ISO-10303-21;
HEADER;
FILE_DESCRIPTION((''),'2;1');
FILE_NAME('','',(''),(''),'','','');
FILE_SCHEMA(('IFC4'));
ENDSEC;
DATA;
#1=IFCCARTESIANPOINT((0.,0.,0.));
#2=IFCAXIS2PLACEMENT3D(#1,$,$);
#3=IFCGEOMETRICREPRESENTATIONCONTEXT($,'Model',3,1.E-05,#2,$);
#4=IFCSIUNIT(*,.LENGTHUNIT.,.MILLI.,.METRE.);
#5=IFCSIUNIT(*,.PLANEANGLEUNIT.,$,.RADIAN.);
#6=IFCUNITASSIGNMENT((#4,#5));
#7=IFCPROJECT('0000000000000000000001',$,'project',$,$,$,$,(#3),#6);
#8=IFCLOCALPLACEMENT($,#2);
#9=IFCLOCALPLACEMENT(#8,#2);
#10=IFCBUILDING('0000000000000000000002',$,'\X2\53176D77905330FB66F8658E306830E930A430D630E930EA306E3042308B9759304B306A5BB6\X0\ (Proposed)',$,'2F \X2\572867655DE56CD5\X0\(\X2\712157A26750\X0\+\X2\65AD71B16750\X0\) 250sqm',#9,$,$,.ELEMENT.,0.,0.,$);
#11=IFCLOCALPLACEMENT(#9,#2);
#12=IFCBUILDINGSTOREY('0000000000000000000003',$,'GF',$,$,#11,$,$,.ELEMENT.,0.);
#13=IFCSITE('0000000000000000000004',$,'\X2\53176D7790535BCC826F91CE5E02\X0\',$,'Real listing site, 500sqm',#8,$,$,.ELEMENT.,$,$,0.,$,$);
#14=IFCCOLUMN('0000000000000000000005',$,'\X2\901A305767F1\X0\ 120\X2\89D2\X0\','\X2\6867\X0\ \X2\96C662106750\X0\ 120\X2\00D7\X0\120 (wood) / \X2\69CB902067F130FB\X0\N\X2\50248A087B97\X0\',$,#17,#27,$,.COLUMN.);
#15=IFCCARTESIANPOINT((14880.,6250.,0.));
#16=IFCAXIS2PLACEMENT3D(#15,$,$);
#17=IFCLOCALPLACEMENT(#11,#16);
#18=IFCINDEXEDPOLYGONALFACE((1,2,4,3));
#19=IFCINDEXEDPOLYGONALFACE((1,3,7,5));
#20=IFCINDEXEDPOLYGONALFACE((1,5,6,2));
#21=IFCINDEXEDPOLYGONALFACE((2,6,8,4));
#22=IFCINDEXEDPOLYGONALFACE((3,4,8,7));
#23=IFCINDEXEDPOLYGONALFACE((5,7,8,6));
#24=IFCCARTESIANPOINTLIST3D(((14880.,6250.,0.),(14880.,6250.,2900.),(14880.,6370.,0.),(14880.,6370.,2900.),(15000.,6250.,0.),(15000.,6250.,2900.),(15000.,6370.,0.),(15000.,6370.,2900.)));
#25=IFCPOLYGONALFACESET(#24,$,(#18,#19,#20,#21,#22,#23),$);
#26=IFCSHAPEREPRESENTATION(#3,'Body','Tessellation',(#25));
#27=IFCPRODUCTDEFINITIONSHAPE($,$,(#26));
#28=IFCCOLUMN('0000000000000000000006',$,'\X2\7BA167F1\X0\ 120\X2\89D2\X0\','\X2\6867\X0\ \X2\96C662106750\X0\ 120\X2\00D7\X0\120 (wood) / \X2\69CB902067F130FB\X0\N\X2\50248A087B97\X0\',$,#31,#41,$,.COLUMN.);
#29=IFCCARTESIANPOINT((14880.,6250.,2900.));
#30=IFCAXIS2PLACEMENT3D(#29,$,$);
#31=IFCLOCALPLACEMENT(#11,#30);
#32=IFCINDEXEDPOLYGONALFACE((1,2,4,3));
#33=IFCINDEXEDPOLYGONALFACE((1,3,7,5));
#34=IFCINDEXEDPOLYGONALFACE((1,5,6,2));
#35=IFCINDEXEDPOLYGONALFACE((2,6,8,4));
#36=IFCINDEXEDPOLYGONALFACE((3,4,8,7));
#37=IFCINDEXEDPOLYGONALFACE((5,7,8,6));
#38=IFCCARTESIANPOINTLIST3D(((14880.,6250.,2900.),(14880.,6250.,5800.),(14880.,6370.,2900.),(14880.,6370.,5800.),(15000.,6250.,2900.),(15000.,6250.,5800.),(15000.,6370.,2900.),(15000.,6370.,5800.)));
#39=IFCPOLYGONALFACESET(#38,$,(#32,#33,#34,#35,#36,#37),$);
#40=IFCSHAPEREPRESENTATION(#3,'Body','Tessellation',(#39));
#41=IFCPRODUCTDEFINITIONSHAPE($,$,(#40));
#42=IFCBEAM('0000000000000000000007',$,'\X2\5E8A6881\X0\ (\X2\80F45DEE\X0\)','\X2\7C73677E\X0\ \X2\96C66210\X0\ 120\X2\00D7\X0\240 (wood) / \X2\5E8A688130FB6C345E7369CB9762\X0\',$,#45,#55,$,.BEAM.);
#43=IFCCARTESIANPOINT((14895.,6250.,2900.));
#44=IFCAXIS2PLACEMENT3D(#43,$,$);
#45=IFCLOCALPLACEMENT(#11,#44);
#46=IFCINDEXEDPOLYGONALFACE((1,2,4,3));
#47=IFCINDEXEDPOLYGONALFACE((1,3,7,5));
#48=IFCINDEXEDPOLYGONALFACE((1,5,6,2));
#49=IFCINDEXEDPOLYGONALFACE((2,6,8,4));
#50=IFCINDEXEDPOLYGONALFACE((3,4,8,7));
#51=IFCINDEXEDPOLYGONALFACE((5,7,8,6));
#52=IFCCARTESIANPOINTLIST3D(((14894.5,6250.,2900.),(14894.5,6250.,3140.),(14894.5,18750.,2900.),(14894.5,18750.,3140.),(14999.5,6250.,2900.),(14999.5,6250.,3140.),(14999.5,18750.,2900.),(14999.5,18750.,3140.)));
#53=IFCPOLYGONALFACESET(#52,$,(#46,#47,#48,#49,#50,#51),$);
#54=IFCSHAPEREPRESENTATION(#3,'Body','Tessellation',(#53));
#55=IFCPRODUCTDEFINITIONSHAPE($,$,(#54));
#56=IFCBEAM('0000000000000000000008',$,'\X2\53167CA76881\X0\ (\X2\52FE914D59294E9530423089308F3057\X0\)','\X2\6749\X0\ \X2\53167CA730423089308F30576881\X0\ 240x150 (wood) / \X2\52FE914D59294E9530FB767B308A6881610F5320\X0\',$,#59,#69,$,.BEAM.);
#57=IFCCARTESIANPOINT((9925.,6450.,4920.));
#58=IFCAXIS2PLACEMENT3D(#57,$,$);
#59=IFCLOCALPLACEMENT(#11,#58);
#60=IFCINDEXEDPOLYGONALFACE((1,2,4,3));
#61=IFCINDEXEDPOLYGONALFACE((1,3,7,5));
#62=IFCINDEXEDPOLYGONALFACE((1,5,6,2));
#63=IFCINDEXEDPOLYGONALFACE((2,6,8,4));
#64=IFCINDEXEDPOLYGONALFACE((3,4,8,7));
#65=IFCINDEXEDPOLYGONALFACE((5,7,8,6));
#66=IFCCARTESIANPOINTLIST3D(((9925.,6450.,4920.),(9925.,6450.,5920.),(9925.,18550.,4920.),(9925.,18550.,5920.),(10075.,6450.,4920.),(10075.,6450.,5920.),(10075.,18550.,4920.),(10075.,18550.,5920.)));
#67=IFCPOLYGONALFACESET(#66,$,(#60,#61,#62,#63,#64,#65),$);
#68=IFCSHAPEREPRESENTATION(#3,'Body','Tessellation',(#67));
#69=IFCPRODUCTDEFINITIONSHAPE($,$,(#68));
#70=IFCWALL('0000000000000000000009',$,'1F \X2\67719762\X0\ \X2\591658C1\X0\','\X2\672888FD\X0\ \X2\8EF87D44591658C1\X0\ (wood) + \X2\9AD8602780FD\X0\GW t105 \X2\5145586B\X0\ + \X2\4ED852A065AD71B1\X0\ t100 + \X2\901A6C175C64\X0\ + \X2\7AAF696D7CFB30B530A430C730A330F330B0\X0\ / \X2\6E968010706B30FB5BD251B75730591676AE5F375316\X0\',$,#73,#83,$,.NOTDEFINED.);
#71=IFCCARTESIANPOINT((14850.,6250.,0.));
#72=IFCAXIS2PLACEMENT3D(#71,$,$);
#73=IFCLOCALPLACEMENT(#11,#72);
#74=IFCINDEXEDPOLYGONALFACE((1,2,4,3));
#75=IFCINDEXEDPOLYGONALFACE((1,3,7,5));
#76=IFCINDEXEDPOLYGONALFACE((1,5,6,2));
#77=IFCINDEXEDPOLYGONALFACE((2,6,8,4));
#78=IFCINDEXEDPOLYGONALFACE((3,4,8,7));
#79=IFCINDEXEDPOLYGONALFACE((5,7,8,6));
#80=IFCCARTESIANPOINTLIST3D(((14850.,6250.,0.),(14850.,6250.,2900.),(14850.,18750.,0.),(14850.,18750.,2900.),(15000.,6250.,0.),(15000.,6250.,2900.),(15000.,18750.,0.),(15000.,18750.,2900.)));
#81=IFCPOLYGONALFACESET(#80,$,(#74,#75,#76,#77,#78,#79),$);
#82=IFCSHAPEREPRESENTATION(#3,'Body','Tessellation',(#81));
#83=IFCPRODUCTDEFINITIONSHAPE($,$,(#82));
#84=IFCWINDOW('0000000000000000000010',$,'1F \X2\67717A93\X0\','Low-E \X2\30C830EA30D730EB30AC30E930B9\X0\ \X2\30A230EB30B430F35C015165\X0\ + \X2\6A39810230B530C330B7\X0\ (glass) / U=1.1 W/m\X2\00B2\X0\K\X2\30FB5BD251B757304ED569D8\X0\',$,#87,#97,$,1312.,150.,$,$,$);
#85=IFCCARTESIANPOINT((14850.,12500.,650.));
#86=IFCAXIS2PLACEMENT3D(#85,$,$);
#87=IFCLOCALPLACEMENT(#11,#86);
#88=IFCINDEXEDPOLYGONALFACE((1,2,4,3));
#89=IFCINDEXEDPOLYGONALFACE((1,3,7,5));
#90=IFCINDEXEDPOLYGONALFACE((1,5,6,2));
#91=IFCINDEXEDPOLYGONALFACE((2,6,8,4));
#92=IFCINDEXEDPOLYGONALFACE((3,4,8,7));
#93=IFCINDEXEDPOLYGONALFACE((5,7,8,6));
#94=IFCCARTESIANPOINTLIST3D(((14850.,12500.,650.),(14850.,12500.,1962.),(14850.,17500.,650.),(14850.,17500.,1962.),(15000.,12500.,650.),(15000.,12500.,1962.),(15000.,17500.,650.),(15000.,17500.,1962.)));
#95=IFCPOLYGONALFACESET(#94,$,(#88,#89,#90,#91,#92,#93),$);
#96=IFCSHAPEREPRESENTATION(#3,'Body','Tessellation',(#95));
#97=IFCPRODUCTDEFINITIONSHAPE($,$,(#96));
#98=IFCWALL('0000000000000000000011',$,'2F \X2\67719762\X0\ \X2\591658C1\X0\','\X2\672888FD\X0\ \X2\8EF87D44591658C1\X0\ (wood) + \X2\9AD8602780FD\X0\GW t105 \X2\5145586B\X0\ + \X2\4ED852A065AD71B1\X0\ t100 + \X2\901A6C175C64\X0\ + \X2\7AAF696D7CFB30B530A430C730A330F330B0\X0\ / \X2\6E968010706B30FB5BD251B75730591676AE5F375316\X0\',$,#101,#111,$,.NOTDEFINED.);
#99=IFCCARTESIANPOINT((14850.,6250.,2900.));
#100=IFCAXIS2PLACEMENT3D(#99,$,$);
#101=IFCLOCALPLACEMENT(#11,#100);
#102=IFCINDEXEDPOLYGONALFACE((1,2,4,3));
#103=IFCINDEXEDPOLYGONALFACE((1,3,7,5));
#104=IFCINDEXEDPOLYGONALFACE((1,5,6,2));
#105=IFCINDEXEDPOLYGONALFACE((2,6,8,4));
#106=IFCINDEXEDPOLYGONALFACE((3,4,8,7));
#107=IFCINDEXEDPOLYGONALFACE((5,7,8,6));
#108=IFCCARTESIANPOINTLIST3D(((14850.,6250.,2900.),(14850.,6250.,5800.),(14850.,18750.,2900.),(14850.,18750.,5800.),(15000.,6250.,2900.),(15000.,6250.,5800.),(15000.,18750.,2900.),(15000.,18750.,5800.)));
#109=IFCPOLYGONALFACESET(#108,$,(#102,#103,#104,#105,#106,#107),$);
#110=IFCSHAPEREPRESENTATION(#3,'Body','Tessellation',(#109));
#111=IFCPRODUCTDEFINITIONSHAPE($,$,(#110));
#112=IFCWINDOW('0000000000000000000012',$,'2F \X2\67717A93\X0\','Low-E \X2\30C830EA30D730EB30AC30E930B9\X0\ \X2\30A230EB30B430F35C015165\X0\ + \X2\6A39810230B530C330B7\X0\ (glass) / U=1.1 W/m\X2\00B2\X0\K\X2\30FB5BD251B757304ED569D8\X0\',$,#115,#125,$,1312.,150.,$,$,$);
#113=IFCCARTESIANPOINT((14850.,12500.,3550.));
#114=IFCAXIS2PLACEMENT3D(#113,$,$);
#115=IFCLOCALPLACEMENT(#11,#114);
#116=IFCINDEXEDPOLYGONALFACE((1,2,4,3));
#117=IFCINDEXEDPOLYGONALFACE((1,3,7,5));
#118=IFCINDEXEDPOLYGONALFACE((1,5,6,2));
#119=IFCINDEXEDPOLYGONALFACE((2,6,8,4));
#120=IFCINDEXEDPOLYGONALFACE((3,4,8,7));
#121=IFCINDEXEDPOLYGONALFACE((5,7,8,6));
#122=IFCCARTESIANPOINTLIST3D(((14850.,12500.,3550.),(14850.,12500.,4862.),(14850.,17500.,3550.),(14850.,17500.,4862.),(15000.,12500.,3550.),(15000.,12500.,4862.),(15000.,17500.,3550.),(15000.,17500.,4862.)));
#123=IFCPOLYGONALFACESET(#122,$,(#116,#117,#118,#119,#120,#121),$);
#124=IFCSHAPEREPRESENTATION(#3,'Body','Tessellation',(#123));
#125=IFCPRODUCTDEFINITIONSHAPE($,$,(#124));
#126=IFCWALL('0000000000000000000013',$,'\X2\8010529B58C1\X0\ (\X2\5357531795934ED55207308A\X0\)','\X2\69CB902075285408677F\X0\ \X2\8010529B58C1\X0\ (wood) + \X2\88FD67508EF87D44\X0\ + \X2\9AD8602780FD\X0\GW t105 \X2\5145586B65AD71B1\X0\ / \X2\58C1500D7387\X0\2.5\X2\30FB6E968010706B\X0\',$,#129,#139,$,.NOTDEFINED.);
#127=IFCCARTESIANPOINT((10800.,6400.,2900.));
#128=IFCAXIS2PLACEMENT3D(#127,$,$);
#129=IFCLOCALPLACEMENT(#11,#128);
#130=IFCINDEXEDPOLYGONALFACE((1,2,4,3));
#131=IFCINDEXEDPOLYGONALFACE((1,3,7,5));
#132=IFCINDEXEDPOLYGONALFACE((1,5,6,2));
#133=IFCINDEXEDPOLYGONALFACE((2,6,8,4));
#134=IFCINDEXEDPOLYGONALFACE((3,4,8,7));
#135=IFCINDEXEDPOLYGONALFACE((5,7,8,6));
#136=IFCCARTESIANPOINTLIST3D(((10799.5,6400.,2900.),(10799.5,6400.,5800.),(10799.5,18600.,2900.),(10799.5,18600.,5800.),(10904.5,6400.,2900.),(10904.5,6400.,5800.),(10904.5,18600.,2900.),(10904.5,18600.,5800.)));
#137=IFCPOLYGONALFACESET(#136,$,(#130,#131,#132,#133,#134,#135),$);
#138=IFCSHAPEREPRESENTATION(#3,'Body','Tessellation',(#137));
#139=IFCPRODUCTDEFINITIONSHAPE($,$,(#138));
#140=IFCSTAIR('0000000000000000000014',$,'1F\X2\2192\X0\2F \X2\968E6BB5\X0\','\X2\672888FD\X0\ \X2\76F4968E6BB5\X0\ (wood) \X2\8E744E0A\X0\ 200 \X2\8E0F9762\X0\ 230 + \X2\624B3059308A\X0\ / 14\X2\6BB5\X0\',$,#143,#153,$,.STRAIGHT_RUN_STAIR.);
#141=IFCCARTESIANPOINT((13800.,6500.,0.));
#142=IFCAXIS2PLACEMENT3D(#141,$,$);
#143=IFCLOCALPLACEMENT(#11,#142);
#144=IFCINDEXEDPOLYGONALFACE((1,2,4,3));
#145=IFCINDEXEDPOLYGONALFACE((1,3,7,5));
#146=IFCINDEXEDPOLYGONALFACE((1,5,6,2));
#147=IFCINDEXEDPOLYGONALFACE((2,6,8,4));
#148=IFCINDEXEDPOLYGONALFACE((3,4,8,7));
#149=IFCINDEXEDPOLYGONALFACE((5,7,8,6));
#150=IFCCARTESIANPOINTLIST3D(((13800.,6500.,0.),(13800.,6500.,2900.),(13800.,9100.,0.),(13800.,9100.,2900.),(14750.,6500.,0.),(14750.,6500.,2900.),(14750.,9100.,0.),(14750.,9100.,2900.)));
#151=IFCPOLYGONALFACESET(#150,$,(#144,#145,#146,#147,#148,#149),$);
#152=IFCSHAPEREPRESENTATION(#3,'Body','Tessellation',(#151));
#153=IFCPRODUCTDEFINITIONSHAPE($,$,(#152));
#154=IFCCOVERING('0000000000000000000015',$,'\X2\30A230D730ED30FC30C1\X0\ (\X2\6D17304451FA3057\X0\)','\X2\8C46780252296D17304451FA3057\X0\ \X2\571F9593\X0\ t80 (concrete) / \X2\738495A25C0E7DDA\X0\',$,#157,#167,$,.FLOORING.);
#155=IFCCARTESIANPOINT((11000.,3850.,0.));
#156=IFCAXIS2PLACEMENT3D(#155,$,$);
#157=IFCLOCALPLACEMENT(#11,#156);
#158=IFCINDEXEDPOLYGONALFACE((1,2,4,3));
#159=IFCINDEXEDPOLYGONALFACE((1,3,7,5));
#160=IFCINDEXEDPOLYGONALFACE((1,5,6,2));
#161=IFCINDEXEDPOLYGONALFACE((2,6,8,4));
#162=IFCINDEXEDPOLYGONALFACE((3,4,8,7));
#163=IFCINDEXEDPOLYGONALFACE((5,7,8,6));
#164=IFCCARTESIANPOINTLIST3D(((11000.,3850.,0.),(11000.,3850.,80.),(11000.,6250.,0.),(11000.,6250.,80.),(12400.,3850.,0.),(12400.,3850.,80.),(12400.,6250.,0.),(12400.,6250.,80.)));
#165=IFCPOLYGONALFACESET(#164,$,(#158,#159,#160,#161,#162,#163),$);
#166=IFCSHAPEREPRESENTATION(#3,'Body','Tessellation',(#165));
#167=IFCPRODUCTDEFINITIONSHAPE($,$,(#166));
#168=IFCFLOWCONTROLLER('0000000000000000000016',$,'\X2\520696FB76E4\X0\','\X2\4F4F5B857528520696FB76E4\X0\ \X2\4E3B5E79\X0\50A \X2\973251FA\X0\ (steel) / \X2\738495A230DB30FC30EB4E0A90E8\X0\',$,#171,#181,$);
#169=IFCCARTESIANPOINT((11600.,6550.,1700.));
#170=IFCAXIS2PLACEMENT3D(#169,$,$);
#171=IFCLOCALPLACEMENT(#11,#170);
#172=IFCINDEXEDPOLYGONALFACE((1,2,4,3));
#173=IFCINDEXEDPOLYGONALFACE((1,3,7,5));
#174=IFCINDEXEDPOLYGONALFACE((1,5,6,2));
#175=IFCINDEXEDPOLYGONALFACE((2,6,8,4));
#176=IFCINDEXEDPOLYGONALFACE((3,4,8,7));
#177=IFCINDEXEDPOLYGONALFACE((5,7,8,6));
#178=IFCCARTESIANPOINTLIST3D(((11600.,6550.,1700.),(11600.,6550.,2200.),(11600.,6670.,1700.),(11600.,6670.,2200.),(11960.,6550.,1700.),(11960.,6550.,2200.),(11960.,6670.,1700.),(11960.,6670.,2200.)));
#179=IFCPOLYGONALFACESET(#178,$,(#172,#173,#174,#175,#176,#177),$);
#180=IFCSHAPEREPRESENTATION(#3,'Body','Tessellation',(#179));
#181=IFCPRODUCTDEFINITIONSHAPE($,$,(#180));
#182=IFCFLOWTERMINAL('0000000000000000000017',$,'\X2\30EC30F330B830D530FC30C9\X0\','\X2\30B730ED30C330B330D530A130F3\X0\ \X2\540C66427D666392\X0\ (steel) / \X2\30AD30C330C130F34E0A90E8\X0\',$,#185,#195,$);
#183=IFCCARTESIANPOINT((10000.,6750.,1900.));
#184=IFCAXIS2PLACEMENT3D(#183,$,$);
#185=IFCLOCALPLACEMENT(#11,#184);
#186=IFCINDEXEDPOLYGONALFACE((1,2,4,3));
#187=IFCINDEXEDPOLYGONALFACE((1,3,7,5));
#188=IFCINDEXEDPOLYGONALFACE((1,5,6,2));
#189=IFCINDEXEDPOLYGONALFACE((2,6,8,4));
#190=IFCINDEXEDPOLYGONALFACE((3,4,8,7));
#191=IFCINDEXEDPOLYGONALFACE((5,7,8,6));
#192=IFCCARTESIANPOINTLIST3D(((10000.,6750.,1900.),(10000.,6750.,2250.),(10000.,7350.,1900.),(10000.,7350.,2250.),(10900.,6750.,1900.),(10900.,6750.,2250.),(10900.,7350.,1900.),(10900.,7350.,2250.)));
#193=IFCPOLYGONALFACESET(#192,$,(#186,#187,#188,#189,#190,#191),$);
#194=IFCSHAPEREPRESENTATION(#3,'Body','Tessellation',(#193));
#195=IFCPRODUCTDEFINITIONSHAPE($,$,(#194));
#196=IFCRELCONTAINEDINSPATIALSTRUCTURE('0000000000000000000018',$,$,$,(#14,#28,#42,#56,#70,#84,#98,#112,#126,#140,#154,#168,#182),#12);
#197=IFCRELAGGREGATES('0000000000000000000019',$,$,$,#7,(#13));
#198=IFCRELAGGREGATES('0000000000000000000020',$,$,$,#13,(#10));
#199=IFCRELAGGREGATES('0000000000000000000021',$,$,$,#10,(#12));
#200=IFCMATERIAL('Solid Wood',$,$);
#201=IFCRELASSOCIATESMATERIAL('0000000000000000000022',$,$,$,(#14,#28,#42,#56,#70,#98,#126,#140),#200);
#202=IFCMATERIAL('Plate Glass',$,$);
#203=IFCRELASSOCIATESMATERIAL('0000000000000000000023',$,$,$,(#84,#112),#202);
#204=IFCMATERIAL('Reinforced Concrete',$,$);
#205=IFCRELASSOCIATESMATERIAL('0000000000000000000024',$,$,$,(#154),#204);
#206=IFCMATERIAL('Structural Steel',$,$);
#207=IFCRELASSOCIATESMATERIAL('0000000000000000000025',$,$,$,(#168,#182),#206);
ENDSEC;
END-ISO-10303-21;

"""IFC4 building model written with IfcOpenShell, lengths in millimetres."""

from ifc_helpers import new_model, si_unit, frame, frame_2d, origin, place, context, project, spatial, rectangle, extrude, material, element, fill, save


model = new_model("IFC4")

# Units and contexts
model_context = context("Model", 3, precision=1e-05, world=origin())
ifc_project = project(units=[si_unit("LENGTHUNIT", "METRE", prefix="MILLI"), si_unit("PLANEANGLEUNIT", "RADIAN")], contexts=[model_context])

# Site, building, storey
site_placement = place(None, origin())
site = spatial("IfcSite", under=ifc_project, at=site_placement, Name="北海道富良野市", ObjectType="Real listing site, 500sqm", CompositionType="ELEMENT", RefElevation=0.0)
building_placement = place(site_placement, origin())
building = spatial("IfcBuilding", under=site, at=building_placement, Name="北海道・書斎とライブラリのある静かな家 (Proposed)", ObjectType="2F 在来工法(無垢材+断熱材) 250sqm", CompositionType="ELEMENT", ElevationOfRefHeight=0.0, ElevationOfTerrain=0.0)
storey_placement = place(building_placement, origin())
storey = spatial("IfcBuildingStorey", under=building, at=storey_placement, Name="GF", CompositionType="ELEMENT", Elevation=0.0)

# Columns
ifc_material_1 = material(Name="Solid Wood")
column_1_placement = place(storey_placement, frame((14880.0, 6250.0, 0.0)))
element("IfcColumn", 1, at=column_1_placement, inside=storey, material=ifc_material_1, Name="通し柱 120角", Description="桧 集成材 120×120 (wood) / 構造柱・N値計算", PredefinedType="COLUMN", context=model_context, shape_type="SweptSolid", body=[
    extrude(rectangle(XDim=120.0, YDim=120.0, at=frame_2d((60.0, 60.0))), frame((14880.0, 6250.0, 0.0)), (0.0, 0.0, 1.0), 2900.0),
])
column_2_placement = place(storey_placement, frame((14880.0, 6250.0, 2900.0)))
element("IfcColumn", 2, at=column_2_placement, inside=storey, material=ifc_material_1, Name="管柱 120角", Description="桧 集成材 120×120 (wood) / 構造柱・N値計算", PredefinedType="COLUMN", context=model_context, shape_type="SweptSolid", body=[
    extrude(rectangle(XDim=120.0, YDim=120.0, at=frame_2d((60.0, 60.0))), frame((14880.0, 6250.0, 2900.0)), (0.0, 0.0, 1.0), 2900.0),
])

# Beams
beam_1_placement = place(storey_placement, frame((14895.0, 6250.0, 2900.0)))
element("IfcBeam", 3, at=beam_1_placement, inside=storey, material=ifc_material_1, Name="床梁 (胴差)", Description="米松 集成 120×240 (wood) / 床梁・水平構面", PredefinedType="BEAM", context=model_context, shape_type="SweptSolid", body=[
    extrude(rectangle(XDim=105.0, YDim=12500.0, at=frame_2d((52.0, 6250.0))), frame((14895.0, 6250.0, 2900.0)), (0.0, 0.0, 1.0), 240.0),
])
beam_2_placement = place(storey_placement, frame((9925.0, 6450.0, 4920.0)))
element("IfcBeam", 4, at=beam_2_placement, inside=storey, material=ifc_material_1, Name="化粧梁 (勾配天井あらわし)", Description="杉 化粧あらわし梁 240x150 (wood) / 勾配天井・登り梁意匠", PredefinedType="BEAM", context=model_context, shape_type="SweptSolid", body=[
    extrude(rectangle(XDim=150.0, YDim=12100.0, at=frame_2d((75.0, 6050.0))), frame((9925.0, 6450.0, 4920.0)), (0.0, 0.0, 1.0), 1000.0),
])

# Wall, opening, window
wall_1_placement = place(storey_placement, frame((14850.0, 6250.0, 0.0)))
wall_1 = element("IfcWall", 5, at=wall_1_placement, inside=storey, material=ifc_material_1, Name="1F 東面 外壁", Description="木製 軸組外壁 (wood) + 高性能GW t105 充填 + 付加断熱 t100 + 通気層 + 窯業系サイディング / 準耐火・寒冷地外皮強化", PredefinedType="NOTDEFINED", context=model_context, shape_type="SweptSolid", body=[
    extrude(rectangle(XDim=150.0, YDim=12500.0, at=frame_2d((75.0, 6250.0))), frame((14850.0, 6250.0, 0.0)), (0.0, 0.0, 1.0), 2900.0),
])
opening_1_placement = place(storey_placement, frame((14850.0, 12500.0, 650.0)))
opening_1 = element("IfcOpeningElement", 6, at=opening_1_placement, cuts=wall_1, PredefinedType="NOTDEFINED", context=model_context, shape_type="SweptSolid", body=[
    extrude(rectangle(XDim=150.0, YDim=5000.0, at=frame_2d((75.0, 2500.0))), frame((14850.0, 12500.0, 650.0)), (0.0, 0.0, 1.0), 1312.0),
])
ifc_material_2 = material(Name="Plate Glass")
window_1_placement = place(storey_placement, frame((14850.0, 12500.0, 650.0)))
window_1 = element("IfcWindow", 7, at=window_1_placement, inside=storey, material=ifc_material_2, Name="1F 東窓", Description="Low-E トリプルガラス アルゴン封入 + 樹脂サッシ (glass) / U=1.1 W/m²K・寒冷地仕様", OverallHeight=1312.0, OverallWidth=150.0, context=model_context, shape_type="SweptSolid", body=[
    extrude(rectangle(XDim=150.0, YDim=5000.0, at=frame_2d((75.0, 2500.0))), frame((14850.0, 12500.0, 650.0)), (0.0, 0.0, 1.0), 1312.0),
])
fill(opening_1, window_1)

# Wall, opening, window
wall_2_placement = place(storey_placement, frame((14850.0, 6250.0, 2900.0)))
wall_2 = element("IfcWall", 8, at=wall_2_placement, inside=storey, material=ifc_material_1, Name="2F 東面 外壁", Description="木製 軸組外壁 (wood) + 高性能GW t105 充填 + 付加断熱 t100 + 通気層 + 窯業系サイディング / 準耐火・寒冷地外皮強化", PredefinedType="NOTDEFINED", context=model_context, shape_type="SweptSolid", body=[
    extrude(rectangle(XDim=150.0, YDim=12500.0, at=frame_2d((75.0, 6250.0))), frame((14850.0, 6250.0, 2900.0)), (0.0, 0.0, 1.0), 2900.0),
])
opening_2_placement = place(storey_placement, frame((14850.0, 12500.0, 3550.0)))
opening_2 = element("IfcOpeningElement", 9, at=opening_2_placement, cuts=wall_2, PredefinedType="NOTDEFINED", context=model_context, shape_type="SweptSolid", body=[
    extrude(rectangle(XDim=150.0, YDim=5000.0, at=frame_2d((75.0, 2500.0))), frame((14850.0, 12500.0, 3550.0)), (0.0, 0.0, 1.0), 1312.0),
])
window_2_placement = place(storey_placement, frame((14850.0, 12500.0, 3550.0)))
window_2 = element("IfcWindow", 10, at=window_2_placement, inside=storey, material=ifc_material_2, Name="2F 東窓", Description="Low-E トリプルガラス アルゴン封入 + 樹脂サッシ (glass) / U=1.1 W/m²K・寒冷地仕様", OverallHeight=1312.0, OverallWidth=150.0, context=model_context, shape_type="SweptSolid", body=[
    extrude(rectangle(XDim=150.0, YDim=5000.0, at=frame_2d((75.0, 2500.0))), frame((14850.0, 12500.0, 3550.0)), (0.0, 0.0, 1.0), 1312.0),
])
fill(opening_2, window_2)

# Wall
wall_3_placement = place(storey_placement, frame((10800.0, 6400.0, 2900.0)))
element("IfcWall", 11, at=wall_3_placement, inside=storey, material=ifc_material_1, Name="耐力壁 (南北間仕切り)", Description="構造用合板 耐力壁 (wood) + 製材軸組 + 高性能GW t105 充填断熱 / 壁倍率2.5・準耐火", PredefinedType="NOTDEFINED", context=model_context, shape_type="SweptSolid", body=[
    extrude(rectangle(XDim=105.0, YDim=12200.0, at=frame_2d((52.0, 6100.0))), frame((10800.0, 6400.0, 2900.0)), (0.0, 0.0, 1.0), 2900.0),
])

# Stair
stair_placement = place(storey_placement, frame((13800.0, 6500.0, 0.0)))
element("IfcStair", 12, at=stair_placement, inside=storey, material=ifc_material_1, Name="1F→2F 階段", Description="木製 直階段 (wood) 蹴上 200 踏面 230 + 手すり / 14段", PredefinedType="STRAIGHT_RUN_STAIR", context=model_context, shape_type="SweptSolid", body=[
    extrude(rectangle(XDim=950.0, YDim=2600.0, at=frame_2d((475.0, 1300.0))), frame((13800.0, 6500.0, 0.0)), (0.0, 0.0, 1.0), 2900.0),
])

# Covering
ifc_material_3 = material(Name="Reinforced Concrete")
covering_placement = place(storey_placement, frame((11000.0, 3850.0, 0.0)))
element("IfcCovering", 13, at=covering_placement, inside=storey, material=ifc_material_3, Name="アプローチ (洗い出し)", Description="豆砂利洗い出し 土間 t80 (concrete) / 玄関導線", PredefinedType="FLOORING", context=model_context, shape_type="SweptSolid", body=[
    extrude(rectangle(XDim=1400.0, YDim=2400.0, at=frame_2d((700.0, 1200.0))), frame((11000.0, 3850.0, 0.0)), (0.0, 0.0, 1.0), 80.0),
])

# Flow controller
ifc_material_4 = material(Name="Structural Steel")
flow_controller_placement = place(storey_placement, frame((11600.0, 6550.0, 1700.0)))
element("IfcFlowController", 14, at=flow_controller_placement, inside=storey, material=ifc_material_4, Name="分電盤", Description="住宅用分電盤 主幹50A 露出 (steel) / 玄関ホール上部", context=model_context, shape_type="SweptSolid", body=[
    extrude(rectangle(XDim=360.0, YDim=120.0, at=frame_2d((180.0, 60.0))), frame((11600.0, 6550.0, 1700.0)), (0.0, 0.0, 1.0), 500.0),
])

# Flow terminal
flow_terminal_1_placement = place(storey_placement, frame((10000.0, 6750.0, 1900.0)))
element("IfcFlowTerminal", 15, at=flow_terminal_1_placement, inside=storey, material=ifc_material_4, Name="レンジフード", Description="シロッコファン 同時給排 (steel) / キッチン上部", context=model_context, shape_type="SweptSolid", body=[
    extrude(rectangle(XDim=900.0, YDim=600.0, at=frame_2d((450.0, 300.0))), frame((10000.0, 6750.0, 1900.0)), (0.0, 0.0, 1.0), 350.0),
])

save(model, "model.ifc")
